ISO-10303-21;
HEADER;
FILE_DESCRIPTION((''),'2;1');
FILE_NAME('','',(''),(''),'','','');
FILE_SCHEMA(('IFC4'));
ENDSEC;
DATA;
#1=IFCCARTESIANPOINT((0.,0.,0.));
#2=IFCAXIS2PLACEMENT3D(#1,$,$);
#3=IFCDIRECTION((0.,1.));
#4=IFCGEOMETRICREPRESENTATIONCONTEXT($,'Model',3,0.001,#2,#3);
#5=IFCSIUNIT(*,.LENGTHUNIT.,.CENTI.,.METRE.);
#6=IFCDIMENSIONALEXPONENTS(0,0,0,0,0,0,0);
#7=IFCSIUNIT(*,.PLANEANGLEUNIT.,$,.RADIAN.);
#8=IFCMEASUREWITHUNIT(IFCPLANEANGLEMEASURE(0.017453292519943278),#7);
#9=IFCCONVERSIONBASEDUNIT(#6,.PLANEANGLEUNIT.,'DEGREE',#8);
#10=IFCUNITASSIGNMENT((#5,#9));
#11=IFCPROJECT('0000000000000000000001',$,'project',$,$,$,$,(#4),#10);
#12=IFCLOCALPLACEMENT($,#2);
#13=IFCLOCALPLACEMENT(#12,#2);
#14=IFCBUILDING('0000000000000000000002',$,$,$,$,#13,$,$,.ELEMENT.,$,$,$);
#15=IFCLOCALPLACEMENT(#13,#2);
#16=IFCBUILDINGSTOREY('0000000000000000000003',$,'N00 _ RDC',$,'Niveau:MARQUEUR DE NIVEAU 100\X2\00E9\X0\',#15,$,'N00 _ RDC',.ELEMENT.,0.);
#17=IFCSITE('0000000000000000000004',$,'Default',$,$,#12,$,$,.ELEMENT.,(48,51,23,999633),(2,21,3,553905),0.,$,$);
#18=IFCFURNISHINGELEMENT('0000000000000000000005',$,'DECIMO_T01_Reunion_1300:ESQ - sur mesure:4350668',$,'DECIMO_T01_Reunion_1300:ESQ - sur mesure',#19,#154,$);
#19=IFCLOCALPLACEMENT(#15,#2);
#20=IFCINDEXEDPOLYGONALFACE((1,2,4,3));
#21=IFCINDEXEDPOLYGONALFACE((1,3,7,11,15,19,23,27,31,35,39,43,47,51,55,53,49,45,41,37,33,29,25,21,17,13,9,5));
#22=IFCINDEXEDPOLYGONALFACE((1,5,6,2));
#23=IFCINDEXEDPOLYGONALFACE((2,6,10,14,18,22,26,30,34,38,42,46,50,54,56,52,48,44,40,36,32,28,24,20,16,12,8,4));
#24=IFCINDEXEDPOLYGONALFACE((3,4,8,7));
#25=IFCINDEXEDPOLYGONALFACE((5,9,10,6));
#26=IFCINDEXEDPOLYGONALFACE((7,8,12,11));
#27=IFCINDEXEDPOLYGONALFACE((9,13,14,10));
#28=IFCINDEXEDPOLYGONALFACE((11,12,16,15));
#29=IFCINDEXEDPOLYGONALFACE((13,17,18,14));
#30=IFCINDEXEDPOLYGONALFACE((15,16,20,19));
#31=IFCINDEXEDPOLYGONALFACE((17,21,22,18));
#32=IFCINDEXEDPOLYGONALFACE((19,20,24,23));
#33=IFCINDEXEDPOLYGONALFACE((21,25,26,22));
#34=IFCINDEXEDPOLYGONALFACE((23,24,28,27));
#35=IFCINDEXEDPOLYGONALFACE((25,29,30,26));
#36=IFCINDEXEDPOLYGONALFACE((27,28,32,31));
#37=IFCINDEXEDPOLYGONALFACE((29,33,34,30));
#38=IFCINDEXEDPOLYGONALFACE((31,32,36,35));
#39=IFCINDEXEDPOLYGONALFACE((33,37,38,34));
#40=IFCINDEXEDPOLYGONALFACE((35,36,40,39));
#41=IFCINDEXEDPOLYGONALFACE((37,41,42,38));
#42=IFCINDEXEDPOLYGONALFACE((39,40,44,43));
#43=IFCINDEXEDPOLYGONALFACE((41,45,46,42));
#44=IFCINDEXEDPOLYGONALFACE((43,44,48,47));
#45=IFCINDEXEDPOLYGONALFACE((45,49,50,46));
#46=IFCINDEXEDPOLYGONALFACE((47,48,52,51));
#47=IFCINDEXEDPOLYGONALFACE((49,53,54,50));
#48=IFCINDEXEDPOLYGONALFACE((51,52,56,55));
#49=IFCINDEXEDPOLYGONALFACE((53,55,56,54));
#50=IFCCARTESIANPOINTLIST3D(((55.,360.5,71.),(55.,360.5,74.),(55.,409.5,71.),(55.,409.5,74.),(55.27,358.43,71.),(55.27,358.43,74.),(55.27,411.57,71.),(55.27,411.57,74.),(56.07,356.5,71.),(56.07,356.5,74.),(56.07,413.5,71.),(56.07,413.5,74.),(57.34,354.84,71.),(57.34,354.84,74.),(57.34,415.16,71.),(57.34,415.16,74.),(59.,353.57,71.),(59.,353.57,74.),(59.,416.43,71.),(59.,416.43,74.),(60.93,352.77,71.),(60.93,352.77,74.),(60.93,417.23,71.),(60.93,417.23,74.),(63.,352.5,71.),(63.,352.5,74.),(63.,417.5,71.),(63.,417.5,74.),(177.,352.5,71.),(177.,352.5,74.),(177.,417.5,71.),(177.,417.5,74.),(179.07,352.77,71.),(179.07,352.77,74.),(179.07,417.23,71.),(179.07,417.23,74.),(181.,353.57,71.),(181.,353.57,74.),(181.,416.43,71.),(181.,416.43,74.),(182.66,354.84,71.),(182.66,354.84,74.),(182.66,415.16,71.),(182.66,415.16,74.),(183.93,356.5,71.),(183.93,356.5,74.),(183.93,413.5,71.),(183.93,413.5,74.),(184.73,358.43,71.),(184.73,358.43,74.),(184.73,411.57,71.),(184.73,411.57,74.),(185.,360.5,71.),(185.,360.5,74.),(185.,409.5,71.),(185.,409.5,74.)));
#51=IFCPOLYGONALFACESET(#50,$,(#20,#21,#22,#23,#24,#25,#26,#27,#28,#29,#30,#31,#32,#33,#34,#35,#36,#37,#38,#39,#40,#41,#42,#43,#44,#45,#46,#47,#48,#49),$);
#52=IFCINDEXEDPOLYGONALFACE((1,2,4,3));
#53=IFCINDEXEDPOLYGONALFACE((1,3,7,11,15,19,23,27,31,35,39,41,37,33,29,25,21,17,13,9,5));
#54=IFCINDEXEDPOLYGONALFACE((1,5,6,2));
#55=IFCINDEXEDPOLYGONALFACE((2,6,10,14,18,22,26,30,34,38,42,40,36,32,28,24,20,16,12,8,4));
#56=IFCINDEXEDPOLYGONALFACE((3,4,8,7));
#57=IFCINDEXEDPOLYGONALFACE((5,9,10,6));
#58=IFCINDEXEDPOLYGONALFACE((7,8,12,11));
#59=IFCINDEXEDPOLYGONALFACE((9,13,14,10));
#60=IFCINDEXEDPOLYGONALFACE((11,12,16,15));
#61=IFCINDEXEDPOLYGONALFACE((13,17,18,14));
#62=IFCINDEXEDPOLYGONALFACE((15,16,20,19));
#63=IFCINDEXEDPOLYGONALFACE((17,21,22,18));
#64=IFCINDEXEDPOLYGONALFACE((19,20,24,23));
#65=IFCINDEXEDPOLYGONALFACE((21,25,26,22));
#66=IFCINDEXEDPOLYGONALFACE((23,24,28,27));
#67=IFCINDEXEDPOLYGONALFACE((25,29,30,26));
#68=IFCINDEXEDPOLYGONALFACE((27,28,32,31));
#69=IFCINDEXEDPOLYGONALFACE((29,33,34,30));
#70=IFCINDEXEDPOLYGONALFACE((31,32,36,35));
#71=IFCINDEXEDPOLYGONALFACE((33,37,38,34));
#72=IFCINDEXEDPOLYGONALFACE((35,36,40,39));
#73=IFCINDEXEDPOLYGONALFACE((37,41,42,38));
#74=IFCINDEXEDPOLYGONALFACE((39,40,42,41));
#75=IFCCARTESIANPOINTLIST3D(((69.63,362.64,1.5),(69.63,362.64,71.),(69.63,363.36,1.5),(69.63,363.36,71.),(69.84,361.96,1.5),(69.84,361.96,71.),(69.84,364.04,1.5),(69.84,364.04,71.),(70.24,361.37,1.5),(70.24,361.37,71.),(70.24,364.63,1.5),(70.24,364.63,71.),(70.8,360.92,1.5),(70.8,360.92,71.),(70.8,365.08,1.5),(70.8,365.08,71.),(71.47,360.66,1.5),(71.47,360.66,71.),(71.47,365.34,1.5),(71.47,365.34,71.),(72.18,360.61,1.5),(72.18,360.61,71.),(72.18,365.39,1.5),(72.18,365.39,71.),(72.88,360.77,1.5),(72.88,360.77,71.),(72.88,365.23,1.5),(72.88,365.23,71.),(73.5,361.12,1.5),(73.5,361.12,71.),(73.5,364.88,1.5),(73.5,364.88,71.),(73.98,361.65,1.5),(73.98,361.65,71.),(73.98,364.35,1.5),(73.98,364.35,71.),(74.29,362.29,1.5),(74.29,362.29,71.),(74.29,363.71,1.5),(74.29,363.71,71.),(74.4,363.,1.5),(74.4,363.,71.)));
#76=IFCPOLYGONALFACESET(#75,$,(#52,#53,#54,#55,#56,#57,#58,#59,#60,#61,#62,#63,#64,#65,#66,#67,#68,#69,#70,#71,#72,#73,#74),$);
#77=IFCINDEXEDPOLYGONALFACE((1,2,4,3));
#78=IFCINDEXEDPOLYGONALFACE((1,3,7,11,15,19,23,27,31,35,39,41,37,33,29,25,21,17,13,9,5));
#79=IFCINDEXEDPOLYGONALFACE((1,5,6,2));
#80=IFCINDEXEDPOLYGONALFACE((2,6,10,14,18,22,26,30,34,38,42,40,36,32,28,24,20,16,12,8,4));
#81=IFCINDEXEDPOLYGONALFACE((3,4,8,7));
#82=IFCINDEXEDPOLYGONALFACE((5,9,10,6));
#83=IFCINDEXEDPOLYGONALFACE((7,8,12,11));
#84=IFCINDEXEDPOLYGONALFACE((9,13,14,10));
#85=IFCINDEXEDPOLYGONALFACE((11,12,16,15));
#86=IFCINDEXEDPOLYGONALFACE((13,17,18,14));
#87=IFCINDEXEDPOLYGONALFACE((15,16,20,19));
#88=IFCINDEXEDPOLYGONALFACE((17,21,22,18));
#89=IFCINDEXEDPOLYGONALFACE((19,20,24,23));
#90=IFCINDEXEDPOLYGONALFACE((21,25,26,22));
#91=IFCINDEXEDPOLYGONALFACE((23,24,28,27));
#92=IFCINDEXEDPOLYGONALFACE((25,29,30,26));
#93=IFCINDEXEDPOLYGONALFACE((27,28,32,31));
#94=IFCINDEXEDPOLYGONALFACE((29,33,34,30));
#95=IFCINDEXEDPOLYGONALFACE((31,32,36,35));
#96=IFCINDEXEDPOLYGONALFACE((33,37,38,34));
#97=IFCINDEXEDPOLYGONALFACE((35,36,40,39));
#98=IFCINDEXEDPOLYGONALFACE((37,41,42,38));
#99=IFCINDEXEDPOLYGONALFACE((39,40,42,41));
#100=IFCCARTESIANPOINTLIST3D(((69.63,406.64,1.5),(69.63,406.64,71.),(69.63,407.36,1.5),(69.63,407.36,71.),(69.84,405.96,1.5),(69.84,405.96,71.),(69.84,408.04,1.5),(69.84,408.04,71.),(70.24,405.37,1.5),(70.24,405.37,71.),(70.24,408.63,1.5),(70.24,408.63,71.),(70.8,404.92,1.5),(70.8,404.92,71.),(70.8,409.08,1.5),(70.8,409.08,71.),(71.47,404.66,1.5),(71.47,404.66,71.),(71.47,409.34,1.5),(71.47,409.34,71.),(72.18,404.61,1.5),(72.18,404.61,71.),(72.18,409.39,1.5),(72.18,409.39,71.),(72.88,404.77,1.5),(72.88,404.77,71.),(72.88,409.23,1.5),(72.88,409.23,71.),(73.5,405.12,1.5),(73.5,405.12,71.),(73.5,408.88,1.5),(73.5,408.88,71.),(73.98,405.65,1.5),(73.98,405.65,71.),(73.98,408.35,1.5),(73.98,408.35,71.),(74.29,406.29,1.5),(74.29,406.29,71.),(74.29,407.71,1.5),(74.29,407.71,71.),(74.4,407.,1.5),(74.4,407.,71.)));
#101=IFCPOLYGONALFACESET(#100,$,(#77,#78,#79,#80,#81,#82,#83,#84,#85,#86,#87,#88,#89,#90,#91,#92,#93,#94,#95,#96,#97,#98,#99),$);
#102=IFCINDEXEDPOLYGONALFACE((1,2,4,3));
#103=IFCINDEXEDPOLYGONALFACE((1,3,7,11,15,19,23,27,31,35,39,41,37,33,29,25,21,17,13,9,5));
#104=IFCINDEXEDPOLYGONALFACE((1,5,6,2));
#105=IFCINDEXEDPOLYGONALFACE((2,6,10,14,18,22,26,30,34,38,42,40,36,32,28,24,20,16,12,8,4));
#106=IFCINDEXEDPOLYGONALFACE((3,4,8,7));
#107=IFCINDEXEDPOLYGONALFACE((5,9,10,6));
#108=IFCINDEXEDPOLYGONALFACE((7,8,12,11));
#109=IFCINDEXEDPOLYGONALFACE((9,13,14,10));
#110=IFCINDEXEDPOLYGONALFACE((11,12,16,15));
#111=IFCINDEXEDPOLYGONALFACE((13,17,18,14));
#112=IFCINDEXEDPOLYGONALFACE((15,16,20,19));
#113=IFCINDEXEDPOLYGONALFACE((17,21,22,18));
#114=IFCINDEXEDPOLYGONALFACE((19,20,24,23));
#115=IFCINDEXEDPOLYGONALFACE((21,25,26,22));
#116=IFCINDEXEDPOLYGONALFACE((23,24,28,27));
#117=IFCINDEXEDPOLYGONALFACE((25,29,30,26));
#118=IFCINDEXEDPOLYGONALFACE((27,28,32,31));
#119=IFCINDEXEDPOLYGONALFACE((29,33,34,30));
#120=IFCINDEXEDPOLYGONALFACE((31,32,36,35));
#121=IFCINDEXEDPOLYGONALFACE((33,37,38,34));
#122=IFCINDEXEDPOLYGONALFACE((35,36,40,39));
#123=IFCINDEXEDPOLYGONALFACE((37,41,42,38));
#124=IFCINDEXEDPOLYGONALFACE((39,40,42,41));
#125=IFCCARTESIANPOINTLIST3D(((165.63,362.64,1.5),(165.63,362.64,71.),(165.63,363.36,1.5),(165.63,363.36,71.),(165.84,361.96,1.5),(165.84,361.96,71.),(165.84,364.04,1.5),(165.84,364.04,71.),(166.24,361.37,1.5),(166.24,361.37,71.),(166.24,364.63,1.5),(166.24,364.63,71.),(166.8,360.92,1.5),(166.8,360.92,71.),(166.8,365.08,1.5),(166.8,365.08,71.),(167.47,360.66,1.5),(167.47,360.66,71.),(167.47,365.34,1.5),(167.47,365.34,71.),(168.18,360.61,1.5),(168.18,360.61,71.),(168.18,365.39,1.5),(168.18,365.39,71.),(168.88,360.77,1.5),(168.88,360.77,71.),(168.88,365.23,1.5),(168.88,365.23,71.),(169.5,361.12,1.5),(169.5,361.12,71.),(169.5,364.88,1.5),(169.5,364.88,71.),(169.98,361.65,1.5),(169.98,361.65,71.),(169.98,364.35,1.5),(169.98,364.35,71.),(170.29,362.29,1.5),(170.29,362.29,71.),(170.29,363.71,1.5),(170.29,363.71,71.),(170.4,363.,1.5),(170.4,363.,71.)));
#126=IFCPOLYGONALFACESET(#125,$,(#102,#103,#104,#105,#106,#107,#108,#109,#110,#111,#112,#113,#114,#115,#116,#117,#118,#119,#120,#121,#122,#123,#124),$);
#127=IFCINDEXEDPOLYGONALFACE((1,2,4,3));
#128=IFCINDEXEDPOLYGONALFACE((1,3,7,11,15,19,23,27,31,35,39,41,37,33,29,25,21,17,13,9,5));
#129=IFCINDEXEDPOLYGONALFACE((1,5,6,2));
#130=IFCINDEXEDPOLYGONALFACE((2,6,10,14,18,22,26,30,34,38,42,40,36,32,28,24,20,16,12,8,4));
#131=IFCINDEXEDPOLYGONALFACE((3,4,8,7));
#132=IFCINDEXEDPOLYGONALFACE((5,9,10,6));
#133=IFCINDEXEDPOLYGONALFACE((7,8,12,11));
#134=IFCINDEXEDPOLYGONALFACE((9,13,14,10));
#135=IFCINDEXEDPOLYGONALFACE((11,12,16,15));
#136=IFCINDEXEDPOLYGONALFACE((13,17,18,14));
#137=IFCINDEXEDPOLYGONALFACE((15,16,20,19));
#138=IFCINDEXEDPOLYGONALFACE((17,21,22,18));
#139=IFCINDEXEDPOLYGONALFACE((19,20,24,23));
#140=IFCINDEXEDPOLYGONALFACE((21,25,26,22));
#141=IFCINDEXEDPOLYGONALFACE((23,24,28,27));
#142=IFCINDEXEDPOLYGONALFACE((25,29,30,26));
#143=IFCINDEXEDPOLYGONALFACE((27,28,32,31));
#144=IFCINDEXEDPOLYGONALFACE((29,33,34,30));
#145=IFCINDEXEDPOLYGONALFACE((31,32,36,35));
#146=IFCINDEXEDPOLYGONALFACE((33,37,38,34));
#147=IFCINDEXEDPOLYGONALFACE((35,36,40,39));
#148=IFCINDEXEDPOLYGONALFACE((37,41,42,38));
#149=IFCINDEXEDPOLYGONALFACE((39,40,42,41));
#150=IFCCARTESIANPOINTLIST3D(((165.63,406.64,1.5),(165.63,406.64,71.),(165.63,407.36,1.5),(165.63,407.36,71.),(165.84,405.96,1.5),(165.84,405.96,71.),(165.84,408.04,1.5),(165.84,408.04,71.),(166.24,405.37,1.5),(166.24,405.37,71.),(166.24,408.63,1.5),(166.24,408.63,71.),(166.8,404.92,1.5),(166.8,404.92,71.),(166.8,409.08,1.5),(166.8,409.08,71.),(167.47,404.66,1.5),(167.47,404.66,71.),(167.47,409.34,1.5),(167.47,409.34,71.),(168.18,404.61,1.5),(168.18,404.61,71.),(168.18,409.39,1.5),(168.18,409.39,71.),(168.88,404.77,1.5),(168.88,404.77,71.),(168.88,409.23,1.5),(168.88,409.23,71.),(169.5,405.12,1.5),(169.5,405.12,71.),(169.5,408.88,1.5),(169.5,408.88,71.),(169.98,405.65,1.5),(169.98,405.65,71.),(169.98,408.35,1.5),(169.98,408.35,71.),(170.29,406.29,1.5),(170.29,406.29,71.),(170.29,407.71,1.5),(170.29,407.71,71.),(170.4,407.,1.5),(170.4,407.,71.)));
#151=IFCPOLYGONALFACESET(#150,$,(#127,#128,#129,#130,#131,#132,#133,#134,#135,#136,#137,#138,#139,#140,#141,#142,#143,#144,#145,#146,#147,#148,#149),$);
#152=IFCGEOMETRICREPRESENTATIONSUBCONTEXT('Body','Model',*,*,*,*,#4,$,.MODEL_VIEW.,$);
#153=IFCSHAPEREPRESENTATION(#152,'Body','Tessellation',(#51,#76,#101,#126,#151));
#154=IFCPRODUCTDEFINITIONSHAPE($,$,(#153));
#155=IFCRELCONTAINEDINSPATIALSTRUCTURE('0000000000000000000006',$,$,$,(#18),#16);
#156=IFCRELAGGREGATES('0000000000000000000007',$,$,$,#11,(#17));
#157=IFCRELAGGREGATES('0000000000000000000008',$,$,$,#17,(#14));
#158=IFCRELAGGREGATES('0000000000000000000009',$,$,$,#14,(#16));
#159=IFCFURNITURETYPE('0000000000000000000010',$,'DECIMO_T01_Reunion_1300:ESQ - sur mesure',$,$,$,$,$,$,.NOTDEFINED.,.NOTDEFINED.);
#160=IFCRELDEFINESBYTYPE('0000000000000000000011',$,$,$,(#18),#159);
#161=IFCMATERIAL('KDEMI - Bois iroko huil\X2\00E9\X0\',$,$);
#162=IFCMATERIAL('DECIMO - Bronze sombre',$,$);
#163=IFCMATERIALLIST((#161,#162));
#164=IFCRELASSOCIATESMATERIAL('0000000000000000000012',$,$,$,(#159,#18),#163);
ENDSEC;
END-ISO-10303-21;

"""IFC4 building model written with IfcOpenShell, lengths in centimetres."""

from ifc_helpers import new_model, entity, si_unit, converted_unit, direction, frame, frame_2d, origin, origin_2d_with_axis, place, context, subcontext, project, spatial, polyline, circle_curve, parameter, trimmed, segment, composite_curve, circle, outline, extrude, source, transform, mapped, material, material_list, type_object, type_shapes, element, save


model = new_model("IFC4")

# Units and contexts
model_context = context("Model", 3, precision=0.001, world=origin(), true_north=direction((0.0, 1.0)))
body_context = subcontext(model_context, "Body", "Model", "MODEL_VIEW")
ifc_project = project(units=[si_unit("LENGTHUNIT", "METRE", prefix="CENTI"), converted_unit("PLANEANGLEUNIT", "DEGREE", entity("IfcPlaneAngleMeasure", 0.017453292519943278), si_unit("PLANEANGLEUNIT", "RADIAN"), dimensions=[0, 0, 0, 0, 0, 0, 0])], contexts=[model_context])

# Site, building, storey
site_placement = place(None, origin())
site = spatial("IfcSite", under=ifc_project, at=site_placement, Name="Default", CompositionType="ELEMENT", RefLatitude=(48, 51, 23, 999633), RefLongitude=(2, 21, 3, 553905), RefElevation=0.0)
building_placement = place(site_placement, origin())
building = spatial("IfcBuilding", under=site, at=building_placement, CompositionType="ELEMENT")
storey_placement = place(building_placement, origin())
storey = spatial("IfcBuildingStorey", under=building, at=storey_placement, Name="N00 _ RDC", ObjectType="Niveau:MARQUEUR DE NIVEAU 100é", LongName="N00 _ RDC", CompositionType="ELEMENT", Elevation=0.0)

# Furnishing element
ifc_material_1 = material(Name="KDEMI - Bois iroko huilé")
ifc_material_2 = material(Name="DECIMO - Bronze sombre")
ifc_material_list_1 = material_list([ifc_material_1, ifc_material_2])
furniture_type_1 = type_object("IfcFurnitureType", Name="DECIMO_T01_Reunion_1300:ESQ - sur mesure", AssemblyPlace="NOTDEFINED", material=ifc_material_list_1)
shared_shape_1 = source(origin(), body_context, "Body", "SweptSolid", [
    extrude(outline(composite_curve([segment(polyline([(-57.0, -32.5), (57.0, -32.5)]), True, "CONTINUOUS"), segment(trimmed(circle_curve(frame_2d((57.0, -24.5), x_axis=(1.0, 0.0)), 8.0), [parameter(270.0)], [parameter(0.0)], True, "PARAMETER"), True, "CONTINUOUS"), segment(polyline([(65.0, -24.5), (65.0, 24.5)]), True, "CONTINUOUS"), segment(trimmed(circle_curve(frame_2d((57.0, 24.5), x_axis=(1.0, 0.0)), 8.0), [parameter(0.0)], [parameter(90.0)], True, "PARAMETER"), True, "CONTINUOUS"), segment(polyline([(57.0, 32.5), (-57.0, 32.5)]), True, "CONTINUOUS"), segment(trimmed(circle_curve(frame_2d((-57.0, 24.5), x_axis=(1.0, 0.0)), 8.0), [parameter(90.0)], [parameter(180.0)], True, "PARAMETER"), True, "CONTINUOUS"), segment(polyline([(-65.0, 24.5), (-65.0, -24.5)]), True, "CONTINUOUS"), segment(trimmed(circle_curve(frame_2d((-57.0, -24.5), x_axis=(1.0, 0.0)), 8.0), [parameter(180.0)], [parameter(270.0)], True, "PARAMETER"), True, "CONTINUOUS")], self_intersect=False)), frame((0.0, 0.0, 71.0)), (0.0, 0.0, 1.0), 3.0),
    extrude(circle(Radius=2.4, at=origin_2d_with_axis()), frame((-48.0, -22.0, 1.5)), (0.0, 0.0, 1.0), 69.5),
    extrude(circle(Radius=2.4, at=origin_2d_with_axis()), frame((-48.0, 22.0, 1.5)), (0.0, 0.0, 1.0), 69.5),
    extrude(circle(Radius=2.4, at=origin_2d_with_axis()), frame((48.0, -22.0, 1.5)), (0.0, 0.0, 1.0), 69.5),
    extrude(circle(Radius=2.4, at=origin_2d_with_axis()), frame((48.0, 22.0, 1.5)), (0.0, 0.0, 1.0), 69.5),
])
type_shapes(furniture_type_1, [shared_shape_1])
furnishing_1_placement = place(storey_placement, frame((120.0, 385.0, 0.0)))
element("IfcFurnishingElement", 1, at=furnishing_1_placement, inside=storey, type_object=furniture_type_1, material=ifc_material_list_1, Name="DECIMO_T01_Reunion_1300:ESQ - sur mesure:4350668", ObjectType="DECIMO_T01_Reunion_1300:ESQ - sur mesure", context=body_context, shape_type="MappedRepresentation", body=[
    mapped(shared_shape_1, transform((0.0, 0.0, 0.0), scale=1.0)),
])

save(model, "model.ifc")
